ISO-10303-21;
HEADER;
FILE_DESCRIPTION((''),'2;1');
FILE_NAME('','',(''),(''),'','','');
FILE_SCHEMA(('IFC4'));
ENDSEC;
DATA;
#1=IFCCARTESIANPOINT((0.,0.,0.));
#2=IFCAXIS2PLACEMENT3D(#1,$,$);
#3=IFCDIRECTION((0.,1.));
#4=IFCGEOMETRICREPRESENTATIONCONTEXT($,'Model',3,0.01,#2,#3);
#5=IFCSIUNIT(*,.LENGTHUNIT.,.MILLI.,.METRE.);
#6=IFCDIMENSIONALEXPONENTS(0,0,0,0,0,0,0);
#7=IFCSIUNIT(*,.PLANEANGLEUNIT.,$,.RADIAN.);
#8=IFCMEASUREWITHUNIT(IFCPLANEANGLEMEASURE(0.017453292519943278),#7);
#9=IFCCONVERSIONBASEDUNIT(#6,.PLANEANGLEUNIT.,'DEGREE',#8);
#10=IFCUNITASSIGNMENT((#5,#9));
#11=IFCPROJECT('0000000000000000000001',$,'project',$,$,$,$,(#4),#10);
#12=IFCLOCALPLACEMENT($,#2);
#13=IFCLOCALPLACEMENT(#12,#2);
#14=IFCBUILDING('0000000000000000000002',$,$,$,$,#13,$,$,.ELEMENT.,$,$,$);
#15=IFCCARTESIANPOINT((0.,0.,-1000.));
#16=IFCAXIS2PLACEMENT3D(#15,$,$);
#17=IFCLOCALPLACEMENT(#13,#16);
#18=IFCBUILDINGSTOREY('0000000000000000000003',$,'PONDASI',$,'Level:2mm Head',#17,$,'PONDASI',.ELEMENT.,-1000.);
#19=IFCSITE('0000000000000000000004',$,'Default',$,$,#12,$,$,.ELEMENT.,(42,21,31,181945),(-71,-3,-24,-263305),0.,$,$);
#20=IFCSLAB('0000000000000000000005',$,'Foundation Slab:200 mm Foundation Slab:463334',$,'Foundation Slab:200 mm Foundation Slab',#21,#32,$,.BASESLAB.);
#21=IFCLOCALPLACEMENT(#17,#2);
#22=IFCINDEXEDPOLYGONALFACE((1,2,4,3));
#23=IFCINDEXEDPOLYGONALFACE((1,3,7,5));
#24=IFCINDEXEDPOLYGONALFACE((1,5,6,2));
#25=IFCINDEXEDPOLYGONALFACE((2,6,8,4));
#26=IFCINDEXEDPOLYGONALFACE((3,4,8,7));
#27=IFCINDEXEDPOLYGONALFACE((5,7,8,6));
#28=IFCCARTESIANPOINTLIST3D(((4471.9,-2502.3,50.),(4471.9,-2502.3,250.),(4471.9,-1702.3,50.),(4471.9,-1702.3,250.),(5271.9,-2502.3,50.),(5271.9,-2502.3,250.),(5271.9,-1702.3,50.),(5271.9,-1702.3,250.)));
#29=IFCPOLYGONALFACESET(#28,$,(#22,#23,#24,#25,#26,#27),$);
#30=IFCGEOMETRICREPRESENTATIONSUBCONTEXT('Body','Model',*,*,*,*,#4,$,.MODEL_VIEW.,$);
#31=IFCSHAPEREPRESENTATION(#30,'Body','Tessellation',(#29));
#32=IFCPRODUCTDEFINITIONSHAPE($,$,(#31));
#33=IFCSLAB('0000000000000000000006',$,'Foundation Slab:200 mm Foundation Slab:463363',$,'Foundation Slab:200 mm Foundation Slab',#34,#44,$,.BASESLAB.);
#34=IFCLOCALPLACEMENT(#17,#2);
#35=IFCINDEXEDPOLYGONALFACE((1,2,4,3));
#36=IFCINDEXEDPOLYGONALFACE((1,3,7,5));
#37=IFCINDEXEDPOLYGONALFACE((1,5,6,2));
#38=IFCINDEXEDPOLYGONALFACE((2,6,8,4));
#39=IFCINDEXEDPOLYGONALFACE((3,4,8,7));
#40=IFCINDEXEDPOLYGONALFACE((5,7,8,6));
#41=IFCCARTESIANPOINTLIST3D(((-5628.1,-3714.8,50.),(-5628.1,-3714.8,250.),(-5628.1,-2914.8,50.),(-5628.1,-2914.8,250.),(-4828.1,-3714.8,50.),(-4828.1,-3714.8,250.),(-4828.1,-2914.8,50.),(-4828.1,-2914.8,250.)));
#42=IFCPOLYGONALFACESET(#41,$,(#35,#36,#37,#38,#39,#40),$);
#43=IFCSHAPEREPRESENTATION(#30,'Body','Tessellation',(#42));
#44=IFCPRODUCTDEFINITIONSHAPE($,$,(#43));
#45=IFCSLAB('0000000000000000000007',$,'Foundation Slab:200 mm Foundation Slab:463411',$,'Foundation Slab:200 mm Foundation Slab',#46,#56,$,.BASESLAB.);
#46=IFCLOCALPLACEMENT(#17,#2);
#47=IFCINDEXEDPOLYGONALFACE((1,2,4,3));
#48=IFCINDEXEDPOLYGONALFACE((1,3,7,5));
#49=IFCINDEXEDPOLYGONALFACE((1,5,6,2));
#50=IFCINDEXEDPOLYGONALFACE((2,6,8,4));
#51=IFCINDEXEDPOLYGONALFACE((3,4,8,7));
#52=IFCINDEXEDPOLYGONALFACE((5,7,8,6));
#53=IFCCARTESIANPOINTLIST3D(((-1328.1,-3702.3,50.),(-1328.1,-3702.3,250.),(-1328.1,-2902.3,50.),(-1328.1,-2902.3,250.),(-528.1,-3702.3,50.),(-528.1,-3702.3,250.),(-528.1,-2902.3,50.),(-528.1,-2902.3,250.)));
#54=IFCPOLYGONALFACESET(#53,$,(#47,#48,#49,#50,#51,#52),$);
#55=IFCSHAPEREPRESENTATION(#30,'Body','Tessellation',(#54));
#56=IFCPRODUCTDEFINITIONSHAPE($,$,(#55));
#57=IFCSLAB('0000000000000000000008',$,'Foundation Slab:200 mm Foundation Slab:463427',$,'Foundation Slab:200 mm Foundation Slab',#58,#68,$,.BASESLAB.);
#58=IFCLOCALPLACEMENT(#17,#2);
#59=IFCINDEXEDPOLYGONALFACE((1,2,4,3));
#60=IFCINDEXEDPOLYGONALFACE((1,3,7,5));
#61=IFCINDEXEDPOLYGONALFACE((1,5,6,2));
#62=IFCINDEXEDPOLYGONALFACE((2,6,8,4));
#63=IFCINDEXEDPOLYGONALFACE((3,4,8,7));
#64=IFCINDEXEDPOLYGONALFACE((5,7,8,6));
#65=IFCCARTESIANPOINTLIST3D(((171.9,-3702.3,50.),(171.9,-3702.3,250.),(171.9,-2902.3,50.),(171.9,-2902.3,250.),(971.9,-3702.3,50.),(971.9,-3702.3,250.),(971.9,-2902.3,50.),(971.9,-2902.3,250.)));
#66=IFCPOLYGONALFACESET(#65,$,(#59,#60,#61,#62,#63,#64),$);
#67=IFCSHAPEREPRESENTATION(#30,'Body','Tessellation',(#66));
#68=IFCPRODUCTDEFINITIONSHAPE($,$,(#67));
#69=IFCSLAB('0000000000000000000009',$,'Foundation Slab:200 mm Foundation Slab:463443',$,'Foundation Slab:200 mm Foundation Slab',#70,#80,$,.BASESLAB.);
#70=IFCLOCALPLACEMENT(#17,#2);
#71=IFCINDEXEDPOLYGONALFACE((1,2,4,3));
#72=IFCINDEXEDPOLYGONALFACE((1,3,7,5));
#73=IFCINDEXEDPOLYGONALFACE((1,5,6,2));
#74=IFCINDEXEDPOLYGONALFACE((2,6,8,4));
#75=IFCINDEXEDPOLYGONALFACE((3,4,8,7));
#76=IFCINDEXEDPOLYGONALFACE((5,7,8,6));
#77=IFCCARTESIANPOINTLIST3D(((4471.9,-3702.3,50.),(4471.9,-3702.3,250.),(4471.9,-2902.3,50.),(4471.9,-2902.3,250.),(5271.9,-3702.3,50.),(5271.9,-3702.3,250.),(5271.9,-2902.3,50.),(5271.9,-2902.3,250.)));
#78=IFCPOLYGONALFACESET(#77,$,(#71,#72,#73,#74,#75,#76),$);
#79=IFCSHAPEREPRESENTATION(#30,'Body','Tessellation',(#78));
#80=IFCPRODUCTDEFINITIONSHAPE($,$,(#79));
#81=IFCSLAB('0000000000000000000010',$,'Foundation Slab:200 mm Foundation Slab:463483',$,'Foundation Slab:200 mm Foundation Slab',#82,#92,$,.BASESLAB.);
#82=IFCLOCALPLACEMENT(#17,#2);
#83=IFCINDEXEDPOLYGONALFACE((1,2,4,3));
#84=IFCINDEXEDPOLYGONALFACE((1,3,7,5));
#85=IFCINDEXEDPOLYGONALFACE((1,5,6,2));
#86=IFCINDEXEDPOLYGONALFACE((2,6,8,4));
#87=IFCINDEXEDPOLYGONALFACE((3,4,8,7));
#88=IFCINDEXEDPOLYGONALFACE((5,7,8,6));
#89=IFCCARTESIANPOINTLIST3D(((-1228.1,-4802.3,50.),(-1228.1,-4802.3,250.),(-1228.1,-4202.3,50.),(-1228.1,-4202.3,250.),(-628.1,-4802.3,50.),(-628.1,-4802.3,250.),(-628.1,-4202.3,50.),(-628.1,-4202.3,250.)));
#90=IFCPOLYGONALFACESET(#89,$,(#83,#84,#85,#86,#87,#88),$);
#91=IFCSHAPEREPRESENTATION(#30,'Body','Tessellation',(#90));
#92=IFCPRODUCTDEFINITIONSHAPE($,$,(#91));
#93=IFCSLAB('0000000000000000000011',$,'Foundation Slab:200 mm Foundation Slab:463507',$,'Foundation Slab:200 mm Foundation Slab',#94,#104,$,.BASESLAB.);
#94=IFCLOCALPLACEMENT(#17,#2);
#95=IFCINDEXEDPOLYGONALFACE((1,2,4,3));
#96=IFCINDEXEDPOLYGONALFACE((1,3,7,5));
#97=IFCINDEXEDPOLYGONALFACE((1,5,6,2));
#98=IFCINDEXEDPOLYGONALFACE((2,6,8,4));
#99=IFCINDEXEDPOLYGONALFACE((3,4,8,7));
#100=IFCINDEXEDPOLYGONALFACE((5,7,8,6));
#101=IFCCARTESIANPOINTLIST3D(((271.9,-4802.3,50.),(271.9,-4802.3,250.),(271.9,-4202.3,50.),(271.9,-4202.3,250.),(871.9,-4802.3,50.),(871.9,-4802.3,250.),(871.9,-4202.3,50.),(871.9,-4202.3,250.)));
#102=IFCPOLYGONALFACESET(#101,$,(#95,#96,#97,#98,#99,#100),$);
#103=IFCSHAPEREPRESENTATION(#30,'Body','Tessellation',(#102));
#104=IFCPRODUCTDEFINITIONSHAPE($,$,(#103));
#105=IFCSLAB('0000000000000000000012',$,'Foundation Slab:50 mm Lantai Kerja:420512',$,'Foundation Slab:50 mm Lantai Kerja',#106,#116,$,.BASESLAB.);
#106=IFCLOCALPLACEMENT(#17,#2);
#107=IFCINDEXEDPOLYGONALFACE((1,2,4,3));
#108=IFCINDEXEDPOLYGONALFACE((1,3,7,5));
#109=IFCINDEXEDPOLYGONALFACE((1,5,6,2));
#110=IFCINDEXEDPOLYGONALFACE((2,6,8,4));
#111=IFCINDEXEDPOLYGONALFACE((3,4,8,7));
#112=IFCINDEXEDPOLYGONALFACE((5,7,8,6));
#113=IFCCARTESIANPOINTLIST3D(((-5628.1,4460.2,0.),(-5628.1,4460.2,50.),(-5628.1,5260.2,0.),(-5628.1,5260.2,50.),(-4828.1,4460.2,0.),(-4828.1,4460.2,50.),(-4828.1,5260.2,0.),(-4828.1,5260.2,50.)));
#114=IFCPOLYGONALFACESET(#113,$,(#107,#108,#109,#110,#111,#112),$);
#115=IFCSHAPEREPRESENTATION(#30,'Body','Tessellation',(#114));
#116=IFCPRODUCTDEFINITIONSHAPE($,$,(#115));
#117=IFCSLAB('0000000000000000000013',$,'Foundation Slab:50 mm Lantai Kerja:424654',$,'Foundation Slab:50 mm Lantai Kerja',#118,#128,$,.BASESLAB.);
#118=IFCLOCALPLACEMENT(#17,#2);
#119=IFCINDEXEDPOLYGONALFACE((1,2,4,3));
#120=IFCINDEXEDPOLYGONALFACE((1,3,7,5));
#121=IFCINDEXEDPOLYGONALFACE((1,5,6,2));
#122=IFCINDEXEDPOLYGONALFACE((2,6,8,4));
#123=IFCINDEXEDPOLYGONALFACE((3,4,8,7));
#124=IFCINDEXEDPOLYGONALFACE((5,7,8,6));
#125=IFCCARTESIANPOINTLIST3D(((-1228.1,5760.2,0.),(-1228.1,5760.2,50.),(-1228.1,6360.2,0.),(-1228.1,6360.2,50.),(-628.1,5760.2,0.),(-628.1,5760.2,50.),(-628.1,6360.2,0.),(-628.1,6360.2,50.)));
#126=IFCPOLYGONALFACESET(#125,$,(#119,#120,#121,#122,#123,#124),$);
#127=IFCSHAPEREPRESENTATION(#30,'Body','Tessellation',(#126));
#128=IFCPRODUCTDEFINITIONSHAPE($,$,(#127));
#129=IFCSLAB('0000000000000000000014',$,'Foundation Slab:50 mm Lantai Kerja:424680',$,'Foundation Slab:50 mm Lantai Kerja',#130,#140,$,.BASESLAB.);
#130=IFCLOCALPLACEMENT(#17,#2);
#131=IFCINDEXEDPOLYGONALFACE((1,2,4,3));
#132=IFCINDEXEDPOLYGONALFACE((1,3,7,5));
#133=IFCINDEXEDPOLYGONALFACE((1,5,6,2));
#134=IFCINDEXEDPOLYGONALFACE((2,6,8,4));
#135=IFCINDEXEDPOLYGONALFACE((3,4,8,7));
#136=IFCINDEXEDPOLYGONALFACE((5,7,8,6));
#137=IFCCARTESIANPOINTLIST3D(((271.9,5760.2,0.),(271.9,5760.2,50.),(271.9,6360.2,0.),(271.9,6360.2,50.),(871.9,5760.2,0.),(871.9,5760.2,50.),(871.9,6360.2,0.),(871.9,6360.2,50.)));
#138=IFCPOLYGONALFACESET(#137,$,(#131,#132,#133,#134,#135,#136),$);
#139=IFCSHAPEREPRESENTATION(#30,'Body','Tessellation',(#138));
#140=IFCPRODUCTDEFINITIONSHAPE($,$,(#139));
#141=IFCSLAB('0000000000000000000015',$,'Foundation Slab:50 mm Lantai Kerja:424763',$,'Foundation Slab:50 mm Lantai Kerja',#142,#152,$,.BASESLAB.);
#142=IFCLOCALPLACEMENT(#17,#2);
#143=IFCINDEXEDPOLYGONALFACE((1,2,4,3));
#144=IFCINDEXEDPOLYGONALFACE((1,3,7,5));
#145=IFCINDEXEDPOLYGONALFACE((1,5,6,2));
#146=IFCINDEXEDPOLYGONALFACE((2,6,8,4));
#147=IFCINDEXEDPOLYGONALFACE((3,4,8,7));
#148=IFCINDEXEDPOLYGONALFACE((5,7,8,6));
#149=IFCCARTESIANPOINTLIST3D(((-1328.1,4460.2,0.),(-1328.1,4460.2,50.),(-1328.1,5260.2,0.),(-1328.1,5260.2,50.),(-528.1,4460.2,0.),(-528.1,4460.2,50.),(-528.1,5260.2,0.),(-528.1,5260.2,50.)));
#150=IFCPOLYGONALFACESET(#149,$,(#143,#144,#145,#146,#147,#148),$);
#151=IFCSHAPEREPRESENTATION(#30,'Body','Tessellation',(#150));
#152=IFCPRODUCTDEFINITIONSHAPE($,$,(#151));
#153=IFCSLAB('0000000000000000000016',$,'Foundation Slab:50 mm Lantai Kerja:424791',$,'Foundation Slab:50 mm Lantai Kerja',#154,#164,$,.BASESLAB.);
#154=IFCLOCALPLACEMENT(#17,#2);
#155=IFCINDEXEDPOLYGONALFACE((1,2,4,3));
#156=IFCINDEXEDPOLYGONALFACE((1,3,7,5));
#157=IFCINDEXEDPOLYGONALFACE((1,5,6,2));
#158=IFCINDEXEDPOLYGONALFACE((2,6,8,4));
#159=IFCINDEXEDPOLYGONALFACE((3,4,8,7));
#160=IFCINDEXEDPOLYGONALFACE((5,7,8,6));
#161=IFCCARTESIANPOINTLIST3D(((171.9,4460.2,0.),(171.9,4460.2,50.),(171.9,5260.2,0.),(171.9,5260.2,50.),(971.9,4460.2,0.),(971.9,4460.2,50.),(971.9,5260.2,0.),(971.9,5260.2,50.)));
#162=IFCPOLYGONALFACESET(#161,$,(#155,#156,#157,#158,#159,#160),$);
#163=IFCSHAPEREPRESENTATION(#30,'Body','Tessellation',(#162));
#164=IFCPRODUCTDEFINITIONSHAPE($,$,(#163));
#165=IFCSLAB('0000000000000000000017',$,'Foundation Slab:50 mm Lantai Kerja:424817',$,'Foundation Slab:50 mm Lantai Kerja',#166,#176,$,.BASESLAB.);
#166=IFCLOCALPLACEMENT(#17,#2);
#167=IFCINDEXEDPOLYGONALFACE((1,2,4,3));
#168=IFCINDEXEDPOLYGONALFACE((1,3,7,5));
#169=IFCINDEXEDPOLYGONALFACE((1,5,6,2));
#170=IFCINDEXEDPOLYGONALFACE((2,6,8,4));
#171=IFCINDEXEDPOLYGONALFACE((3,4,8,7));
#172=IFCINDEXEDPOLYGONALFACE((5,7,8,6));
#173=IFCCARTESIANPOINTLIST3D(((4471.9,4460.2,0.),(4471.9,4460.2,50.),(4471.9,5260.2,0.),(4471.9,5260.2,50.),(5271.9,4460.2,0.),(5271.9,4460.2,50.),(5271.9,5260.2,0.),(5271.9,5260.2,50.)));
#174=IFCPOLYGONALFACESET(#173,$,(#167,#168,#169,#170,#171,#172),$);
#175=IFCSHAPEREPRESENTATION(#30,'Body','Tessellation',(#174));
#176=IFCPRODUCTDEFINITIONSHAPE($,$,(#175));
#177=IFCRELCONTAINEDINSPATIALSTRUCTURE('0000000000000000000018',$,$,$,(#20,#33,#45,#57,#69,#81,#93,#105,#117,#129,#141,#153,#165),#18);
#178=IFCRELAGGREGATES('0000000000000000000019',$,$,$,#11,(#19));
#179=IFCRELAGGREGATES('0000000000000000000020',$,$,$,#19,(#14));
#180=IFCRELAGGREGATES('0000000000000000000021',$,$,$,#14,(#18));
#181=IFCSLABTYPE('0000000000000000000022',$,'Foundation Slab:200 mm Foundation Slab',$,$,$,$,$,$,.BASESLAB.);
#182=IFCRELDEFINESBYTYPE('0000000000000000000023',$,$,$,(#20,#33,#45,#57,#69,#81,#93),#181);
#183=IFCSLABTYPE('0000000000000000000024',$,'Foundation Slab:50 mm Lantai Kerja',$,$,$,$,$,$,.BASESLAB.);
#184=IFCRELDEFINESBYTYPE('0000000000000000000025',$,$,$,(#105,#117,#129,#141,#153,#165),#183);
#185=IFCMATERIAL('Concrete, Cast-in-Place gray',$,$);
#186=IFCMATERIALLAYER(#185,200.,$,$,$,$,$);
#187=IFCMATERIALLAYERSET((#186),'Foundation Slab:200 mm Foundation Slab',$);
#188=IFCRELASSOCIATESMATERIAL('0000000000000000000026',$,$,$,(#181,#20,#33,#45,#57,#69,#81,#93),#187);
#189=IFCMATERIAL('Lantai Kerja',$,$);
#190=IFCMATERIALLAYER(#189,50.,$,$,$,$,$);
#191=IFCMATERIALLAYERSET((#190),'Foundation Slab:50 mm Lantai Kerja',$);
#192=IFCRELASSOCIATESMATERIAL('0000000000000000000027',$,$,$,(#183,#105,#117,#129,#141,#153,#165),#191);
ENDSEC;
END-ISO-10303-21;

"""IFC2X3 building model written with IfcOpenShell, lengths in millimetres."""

from ifc_helpers import new_model, entity, si_unit, converted_unit, direction, frame, origin, origin_2d_with_axis, place, context, subcontext, project, spatial, rectangle, extrude, material, layer, layer_set, layer_usage, type_object, element, save


model = new_model("IFC2X3")

# Units and contexts
model_context = context("Model", 3, precision=0.01, world=origin(), true_north=direction((0.0, 1.0)))
body_context = subcontext(model_context, "Body", "Model", "MODEL_VIEW")
ifc_project = project(units=[si_unit("LENGTHUNIT", "METRE", prefix="MILLI"), converted_unit("PLANEANGLEUNIT", "DEGREE", entity("IfcPlaneAngleMeasure", 0.017453292519943278), si_unit("PLANEANGLEUNIT", "RADIAN"), dimensions=[0, 0, 0, 0, 0, 0, 0])], contexts=[model_context])

# Site, building, storey
site_placement = place(None, origin())
site = spatial("IfcSite", under=ifc_project, at=site_placement, Name="Default", CompositionType="ELEMENT", RefLatitude=(42, 21, 31, 181945), RefLongitude=(-71, -3, -24, -263305), RefElevation=0.0)
building_placement = place(site_placement, origin())
building = spatial("IfcBuilding", under=site, at=building_placement, CompositionType="ELEMENT")
storey_placement = place(building_placement, frame((0.0, 0.0, -1000.0)))
storey = spatial("IfcBuildingStorey", under=building, at=storey_placement, Name="PONDASI", ObjectType="Level:2mm Head", LongName="PONDASI", CompositionType="ELEMENT", Elevation=-1000.0)

# Slabs
ifc_material_1 = material(Name="Concrete, Cast-in-Place gray")
ifc_layer_1 = layer(ifc_material_1, 200.0)
ifc_layer_set_1 = layer_set([ifc_layer_1], Name="Foundation Slab:200 mm Foundation Slab")
slab_type_1 = type_object("IfcSlabType", Name="Foundation Slab:200 mm Foundation Slab", PredefinedType="BASESLAB", material=ifc_layer_set_1)
ifc_layer_usage_1 = layer_usage(ifc_layer_set_1, "AXIS3", "POSITIVE", 0.0)
slab_1_placement = place(storey_placement, origin())
element("IfcSlab", 1, at=slab_1_placement, inside=storey, type_object=slab_type_1, material=ifc_layer_usage_1, Name="Foundation Slab:200 mm Foundation Slab:463334", ObjectType="Foundation Slab:200 mm Foundation Slab", PredefinedType="BASESLAB", context=body_context, shape_type="SweptSolid", body=[
    extrude(rectangle(XDim=800.0, YDim=800.0, at=origin_2d_with_axis()), frame((4871.9, -2102.3, 250.0), z_axis=(0.0, 0.0, -1.0), x_axis=(0.0, 1.0, 0.0)), (0.0, 0.0, 1.0), 200.0),
])
ifc_layer_usage_2 = layer_usage(ifc_layer_set_1, "AXIS3", "POSITIVE", 0.0)
slab_2_placement = place(storey_placement, origin())
element("IfcSlab", 2, at=slab_2_placement, inside=storey, type_object=slab_type_1, material=ifc_layer_usage_2, Name="Foundation Slab:200 mm Foundation Slab:463363", ObjectType="Foundation Slab:200 mm Foundation Slab", PredefinedType="BASESLAB", context=body_context, shape_type="SweptSolid", body=[
    extrude(rectangle(XDim=800.0, YDim=800.0, at=origin_2d_with_axis()), frame((-5228.1, -3314.8, 250.0), z_axis=(0.0, 0.0, -1.0), x_axis=(0.0, 1.0, 0.0)), (0.0, 0.0, 1.0), 200.0),
])
ifc_layer_usage_3 = layer_usage(ifc_layer_set_1, "AXIS3", "POSITIVE", 0.0)
slab_3_placement = place(storey_placement, origin())
element("IfcSlab", 3, at=slab_3_placement, inside=storey, type_object=slab_type_1, material=ifc_layer_usage_3, Name="Foundation Slab:200 mm Foundation Slab:463411", ObjectType="Foundation Slab:200 mm Foundation Slab", PredefinedType="BASESLAB", context=body_context, shape_type="SweptSolid", body=[
    extrude(rectangle(XDim=800.0, YDim=800.0, at=origin_2d_with_axis()), frame((-928.1, -3302.3, 250.0), z_axis=(0.0, 0.0, -1.0), x_axis=(0.0, 1.0, 0.0)), (0.0, 0.0, 1.0), 200.0),
])
ifc_layer_usage_4 = layer_usage(ifc_layer_set_1, "AXIS3", "POSITIVE", 0.0)
slab_4_placement = place(storey_placement, origin())
element("IfcSlab", 4, at=slab_4_placement, inside=storey, type_object=slab_type_1, material=ifc_layer_usage_4, Name="Foundation Slab:200 mm Foundation Slab:463427", ObjectType="Foundation Slab:200 mm Foundation Slab", PredefinedType="BASESLAB", context=body_context, shape_type="SweptSolid", body=[
    extrude(rectangle(XDim=800.0, YDim=800.0, at=origin_2d_with_axis()), frame((571.9, -3302.3, 250.0), z_axis=(0.0, 0.0, -1.0), x_axis=(0.0, 1.0, 0.0)), (0.0, 0.0, 1.0), 200.0),
])
ifc_layer_usage_5 = layer_usage(ifc_layer_set_1, "AXIS3", "POSITIVE", 0.0)
slab_5_placement = place(storey_placement, origin())
element("IfcSlab", 5, at=slab_5_placement, inside=storey, type_object=slab_type_1, material=ifc_layer_usage_5, Name="Foundation Slab:200 mm Foundation Slab:463443", ObjectType="Foundation Slab:200 mm Foundation Slab", PredefinedType="BASESLAB", context=body_context, shape_type="SweptSolid", body=[
    extrude(rectangle(XDim=800.0, YDim=800.0, at=origin_2d_with_axis()), frame((4871.9, -3302.3, 250.0), z_axis=(0.0, 0.0, -1.0), x_axis=(0.0, 1.0, 0.0)), (0.0, 0.0, 1.0), 200.0),
])
ifc_layer_usage_6 = layer_usage(ifc_layer_set_1, "AXIS3", "POSITIVE", 0.0)
slab_6_placement = place(storey_placement, origin())
element("IfcSlab", 6, at=slab_6_placement, inside=storey, type_object=slab_type_1, material=ifc_layer_usage_6, Name="Foundation Slab:200 mm Foundation Slab:463483", ObjectType="Foundation Slab:200 mm Foundation Slab", PredefinedType="BASESLAB", context=body_context, shape_type="SweptSolid", body=[
    extrude(rectangle(XDim=600.0, YDim=600.0, at=origin_2d_with_axis()), frame((-928.1, -4502.3, 250.0), z_axis=(0.0, 0.0, -1.0), x_axis=(0.0, 1.0, 0.0)), (0.0, 0.0, 1.0), 200.0),
])
ifc_layer_usage_7 = layer_usage(ifc_layer_set_1, "AXIS3", "POSITIVE", 0.0)
slab_7_placement = place(storey_placement, origin())
element("IfcSlab", 7, at=slab_7_placement, inside=storey, type_object=slab_type_1, material=ifc_layer_usage_7, Name="Foundation Slab:200 mm Foundation Slab:463507", ObjectType="Foundation Slab:200 mm Foundation Slab", PredefinedType="BASESLAB", context=body_context, shape_type="SweptSolid", body=[
    extrude(rectangle(XDim=600.0, YDim=600.0, at=origin_2d_with_axis()), frame((571.9, -4502.3, 250.0), z_axis=(0.0, 0.0, -1.0), x_axis=(0.0, 1.0, 0.0)), (0.0, 0.0, 1.0), 200.0),
])
ifc_material_2 = material(Name="Lantai Kerja")
ifc_layer_2 = layer(ifc_material_2, 50.0)
ifc_layer_set_2 = layer_set([ifc_layer_2], Name="Foundation Slab:50 mm Lantai Kerja")
ifc_layer_usage_8 = layer_usage(ifc_layer_set_2, "AXIS3", "POSITIVE", 0.0)
slab_type_2 = type_object("IfcSlabType", Name="Foundation Slab:50 mm Lantai Kerja", PredefinedType="BASESLAB", material=ifc_layer_set_2)
slab_8_placement = place(storey_placement, origin())
element("IfcSlab", 8, at=slab_8_placement, inside=storey, type_object=slab_type_2, material=ifc_layer_usage_8, Name="Foundation Slab:50 mm Lantai Kerja:420512", ObjectType="Foundation Slab:50 mm Lantai Kerja", PredefinedType="BASESLAB", context=body_context, shape_type="SweptSolid", body=[
    extrude(rectangle(XDim=800.0, YDim=800.0, at=origin_2d_with_axis()), frame((-5228.1, 4860.2, 50.0), z_axis=(0.0, 0.0, -1.0), x_axis=(0.0, 1.0, 0.0)), (0.0, 0.0, 1.0), 50.0),
])
ifc_layer_usage_9 = layer_usage(ifc_layer_set_2, "AXIS3", "POSITIVE", 0.0)
slab_9_placement = place(storey_placement, origin())
element("IfcSlab", 9, at=slab_9_placement, inside=storey, type_object=slab_type_2, material=ifc_layer_usage_9, Name="Foundation Slab:50 mm Lantai Kerja:424654", ObjectType="Foundation Slab:50 mm Lantai Kerja", PredefinedType="BASESLAB", context=body_context, shape_type="SweptSolid", body=[
    extrude(rectangle(XDim=600.0, YDim=600.0, at=origin_2d_with_axis()), frame((-928.1, 6060.2, 50.0), z_axis=(0.0, 0.0, -1.0), x_axis=(0.0, 1.0, 0.0)), (0.0, 0.0, 1.0), 50.0),
])
ifc_layer_usage_10 = layer_usage(ifc_layer_set_2, "AXIS3", "POSITIVE", 0.0)
slab_10_placement = place(storey_placement, origin())
element("IfcSlab", 10, at=slab_10_placement, inside=storey, type_object=slab_type_2, material=ifc_layer_usage_10, Name="Foundation Slab:50 mm Lantai Kerja:424680", ObjectType="Foundation Slab:50 mm Lantai Kerja", PredefinedType="BASESLAB", context=body_context, shape_type="SweptSolid", body=[
    extrude(rectangle(XDim=600.0, YDim=600.0, at=origin_2d_with_axis()), frame((571.9, 6060.2, 50.0), z_axis=(0.0, 0.0, -1.0), x_axis=(0.0, 1.0, 0.0)), (0.0, 0.0, 1.0), 50.0),
])
ifc_layer_usage_11 = layer_usage(ifc_layer_set_2, "AXIS3", "POSITIVE", 0.0)
slab_11_placement = place(storey_placement, origin())
element("IfcSlab", 11, at=slab_11_placement, inside=storey, type_object=slab_type_2, material=ifc_layer_usage_11, Name="Foundation Slab:50 mm Lantai Kerja:424763", ObjectType="Foundation Slab:50 mm Lantai Kerja", PredefinedType="BASESLAB", context=body_context, shape_type="SweptSolid", body=[
    extrude(rectangle(XDim=800.0, YDim=800.0, at=origin_2d_with_axis()), frame((-928.1, 4860.2, 50.0), z_axis=(0.0, 0.0, -1.0), x_axis=(0.0, 1.0, 0.0)), (0.0, 0.0, 1.0), 50.0),
])
ifc_layer_usage_12 = layer_usage(ifc_layer_set_2, "AXIS3", "POSITIVE", 0.0)
slab_12_placement = place(storey_placement, origin())
element("IfcSlab", 12, at=slab_12_placement, inside=storey, type_object=slab_type_2, material=ifc_layer_usage_12, Name="Foundation Slab:50 mm Lantai Kerja:424791", ObjectType="Foundation Slab:50 mm Lantai Kerja", PredefinedType="BASESLAB", context=body_context, shape_type="SweptSolid", body=[
    extrude(rectangle(XDim=800.0, YDim=800.0, at=origin_2d_with_axis()), frame((571.9, 4860.2, 50.0), z_axis=(0.0, 0.0, -1.0), x_axis=(0.0, 1.0, 0.0)), (0.0, 0.0, 1.0), 50.0),
])
ifc_layer_usage_13 = layer_usage(ifc_layer_set_2, "AXIS3", "POSITIVE", 0.0)
slab_13_placement = place(storey_placement, origin())
element("IfcSlab", 13, at=slab_13_placement, inside=storey, type_object=slab_type_2, material=ifc_layer_usage_13, Name="Foundation Slab:50 mm Lantai Kerja:424817", ObjectType="Foundation Slab:50 mm Lantai Kerja", PredefinedType="BASESLAB", context=body_context, shape_type="SweptSolid", body=[
    extrude(rectangle(XDim=800.0, YDim=800.0, at=origin_2d_with_axis()), frame((4871.9, 4860.2, 50.0), z_axis=(0.0, 0.0, -1.0), x_axis=(0.0, 1.0, 0.0)), (0.0, 0.0, 1.0), 50.0),
])

save(model, "model.ifc")
